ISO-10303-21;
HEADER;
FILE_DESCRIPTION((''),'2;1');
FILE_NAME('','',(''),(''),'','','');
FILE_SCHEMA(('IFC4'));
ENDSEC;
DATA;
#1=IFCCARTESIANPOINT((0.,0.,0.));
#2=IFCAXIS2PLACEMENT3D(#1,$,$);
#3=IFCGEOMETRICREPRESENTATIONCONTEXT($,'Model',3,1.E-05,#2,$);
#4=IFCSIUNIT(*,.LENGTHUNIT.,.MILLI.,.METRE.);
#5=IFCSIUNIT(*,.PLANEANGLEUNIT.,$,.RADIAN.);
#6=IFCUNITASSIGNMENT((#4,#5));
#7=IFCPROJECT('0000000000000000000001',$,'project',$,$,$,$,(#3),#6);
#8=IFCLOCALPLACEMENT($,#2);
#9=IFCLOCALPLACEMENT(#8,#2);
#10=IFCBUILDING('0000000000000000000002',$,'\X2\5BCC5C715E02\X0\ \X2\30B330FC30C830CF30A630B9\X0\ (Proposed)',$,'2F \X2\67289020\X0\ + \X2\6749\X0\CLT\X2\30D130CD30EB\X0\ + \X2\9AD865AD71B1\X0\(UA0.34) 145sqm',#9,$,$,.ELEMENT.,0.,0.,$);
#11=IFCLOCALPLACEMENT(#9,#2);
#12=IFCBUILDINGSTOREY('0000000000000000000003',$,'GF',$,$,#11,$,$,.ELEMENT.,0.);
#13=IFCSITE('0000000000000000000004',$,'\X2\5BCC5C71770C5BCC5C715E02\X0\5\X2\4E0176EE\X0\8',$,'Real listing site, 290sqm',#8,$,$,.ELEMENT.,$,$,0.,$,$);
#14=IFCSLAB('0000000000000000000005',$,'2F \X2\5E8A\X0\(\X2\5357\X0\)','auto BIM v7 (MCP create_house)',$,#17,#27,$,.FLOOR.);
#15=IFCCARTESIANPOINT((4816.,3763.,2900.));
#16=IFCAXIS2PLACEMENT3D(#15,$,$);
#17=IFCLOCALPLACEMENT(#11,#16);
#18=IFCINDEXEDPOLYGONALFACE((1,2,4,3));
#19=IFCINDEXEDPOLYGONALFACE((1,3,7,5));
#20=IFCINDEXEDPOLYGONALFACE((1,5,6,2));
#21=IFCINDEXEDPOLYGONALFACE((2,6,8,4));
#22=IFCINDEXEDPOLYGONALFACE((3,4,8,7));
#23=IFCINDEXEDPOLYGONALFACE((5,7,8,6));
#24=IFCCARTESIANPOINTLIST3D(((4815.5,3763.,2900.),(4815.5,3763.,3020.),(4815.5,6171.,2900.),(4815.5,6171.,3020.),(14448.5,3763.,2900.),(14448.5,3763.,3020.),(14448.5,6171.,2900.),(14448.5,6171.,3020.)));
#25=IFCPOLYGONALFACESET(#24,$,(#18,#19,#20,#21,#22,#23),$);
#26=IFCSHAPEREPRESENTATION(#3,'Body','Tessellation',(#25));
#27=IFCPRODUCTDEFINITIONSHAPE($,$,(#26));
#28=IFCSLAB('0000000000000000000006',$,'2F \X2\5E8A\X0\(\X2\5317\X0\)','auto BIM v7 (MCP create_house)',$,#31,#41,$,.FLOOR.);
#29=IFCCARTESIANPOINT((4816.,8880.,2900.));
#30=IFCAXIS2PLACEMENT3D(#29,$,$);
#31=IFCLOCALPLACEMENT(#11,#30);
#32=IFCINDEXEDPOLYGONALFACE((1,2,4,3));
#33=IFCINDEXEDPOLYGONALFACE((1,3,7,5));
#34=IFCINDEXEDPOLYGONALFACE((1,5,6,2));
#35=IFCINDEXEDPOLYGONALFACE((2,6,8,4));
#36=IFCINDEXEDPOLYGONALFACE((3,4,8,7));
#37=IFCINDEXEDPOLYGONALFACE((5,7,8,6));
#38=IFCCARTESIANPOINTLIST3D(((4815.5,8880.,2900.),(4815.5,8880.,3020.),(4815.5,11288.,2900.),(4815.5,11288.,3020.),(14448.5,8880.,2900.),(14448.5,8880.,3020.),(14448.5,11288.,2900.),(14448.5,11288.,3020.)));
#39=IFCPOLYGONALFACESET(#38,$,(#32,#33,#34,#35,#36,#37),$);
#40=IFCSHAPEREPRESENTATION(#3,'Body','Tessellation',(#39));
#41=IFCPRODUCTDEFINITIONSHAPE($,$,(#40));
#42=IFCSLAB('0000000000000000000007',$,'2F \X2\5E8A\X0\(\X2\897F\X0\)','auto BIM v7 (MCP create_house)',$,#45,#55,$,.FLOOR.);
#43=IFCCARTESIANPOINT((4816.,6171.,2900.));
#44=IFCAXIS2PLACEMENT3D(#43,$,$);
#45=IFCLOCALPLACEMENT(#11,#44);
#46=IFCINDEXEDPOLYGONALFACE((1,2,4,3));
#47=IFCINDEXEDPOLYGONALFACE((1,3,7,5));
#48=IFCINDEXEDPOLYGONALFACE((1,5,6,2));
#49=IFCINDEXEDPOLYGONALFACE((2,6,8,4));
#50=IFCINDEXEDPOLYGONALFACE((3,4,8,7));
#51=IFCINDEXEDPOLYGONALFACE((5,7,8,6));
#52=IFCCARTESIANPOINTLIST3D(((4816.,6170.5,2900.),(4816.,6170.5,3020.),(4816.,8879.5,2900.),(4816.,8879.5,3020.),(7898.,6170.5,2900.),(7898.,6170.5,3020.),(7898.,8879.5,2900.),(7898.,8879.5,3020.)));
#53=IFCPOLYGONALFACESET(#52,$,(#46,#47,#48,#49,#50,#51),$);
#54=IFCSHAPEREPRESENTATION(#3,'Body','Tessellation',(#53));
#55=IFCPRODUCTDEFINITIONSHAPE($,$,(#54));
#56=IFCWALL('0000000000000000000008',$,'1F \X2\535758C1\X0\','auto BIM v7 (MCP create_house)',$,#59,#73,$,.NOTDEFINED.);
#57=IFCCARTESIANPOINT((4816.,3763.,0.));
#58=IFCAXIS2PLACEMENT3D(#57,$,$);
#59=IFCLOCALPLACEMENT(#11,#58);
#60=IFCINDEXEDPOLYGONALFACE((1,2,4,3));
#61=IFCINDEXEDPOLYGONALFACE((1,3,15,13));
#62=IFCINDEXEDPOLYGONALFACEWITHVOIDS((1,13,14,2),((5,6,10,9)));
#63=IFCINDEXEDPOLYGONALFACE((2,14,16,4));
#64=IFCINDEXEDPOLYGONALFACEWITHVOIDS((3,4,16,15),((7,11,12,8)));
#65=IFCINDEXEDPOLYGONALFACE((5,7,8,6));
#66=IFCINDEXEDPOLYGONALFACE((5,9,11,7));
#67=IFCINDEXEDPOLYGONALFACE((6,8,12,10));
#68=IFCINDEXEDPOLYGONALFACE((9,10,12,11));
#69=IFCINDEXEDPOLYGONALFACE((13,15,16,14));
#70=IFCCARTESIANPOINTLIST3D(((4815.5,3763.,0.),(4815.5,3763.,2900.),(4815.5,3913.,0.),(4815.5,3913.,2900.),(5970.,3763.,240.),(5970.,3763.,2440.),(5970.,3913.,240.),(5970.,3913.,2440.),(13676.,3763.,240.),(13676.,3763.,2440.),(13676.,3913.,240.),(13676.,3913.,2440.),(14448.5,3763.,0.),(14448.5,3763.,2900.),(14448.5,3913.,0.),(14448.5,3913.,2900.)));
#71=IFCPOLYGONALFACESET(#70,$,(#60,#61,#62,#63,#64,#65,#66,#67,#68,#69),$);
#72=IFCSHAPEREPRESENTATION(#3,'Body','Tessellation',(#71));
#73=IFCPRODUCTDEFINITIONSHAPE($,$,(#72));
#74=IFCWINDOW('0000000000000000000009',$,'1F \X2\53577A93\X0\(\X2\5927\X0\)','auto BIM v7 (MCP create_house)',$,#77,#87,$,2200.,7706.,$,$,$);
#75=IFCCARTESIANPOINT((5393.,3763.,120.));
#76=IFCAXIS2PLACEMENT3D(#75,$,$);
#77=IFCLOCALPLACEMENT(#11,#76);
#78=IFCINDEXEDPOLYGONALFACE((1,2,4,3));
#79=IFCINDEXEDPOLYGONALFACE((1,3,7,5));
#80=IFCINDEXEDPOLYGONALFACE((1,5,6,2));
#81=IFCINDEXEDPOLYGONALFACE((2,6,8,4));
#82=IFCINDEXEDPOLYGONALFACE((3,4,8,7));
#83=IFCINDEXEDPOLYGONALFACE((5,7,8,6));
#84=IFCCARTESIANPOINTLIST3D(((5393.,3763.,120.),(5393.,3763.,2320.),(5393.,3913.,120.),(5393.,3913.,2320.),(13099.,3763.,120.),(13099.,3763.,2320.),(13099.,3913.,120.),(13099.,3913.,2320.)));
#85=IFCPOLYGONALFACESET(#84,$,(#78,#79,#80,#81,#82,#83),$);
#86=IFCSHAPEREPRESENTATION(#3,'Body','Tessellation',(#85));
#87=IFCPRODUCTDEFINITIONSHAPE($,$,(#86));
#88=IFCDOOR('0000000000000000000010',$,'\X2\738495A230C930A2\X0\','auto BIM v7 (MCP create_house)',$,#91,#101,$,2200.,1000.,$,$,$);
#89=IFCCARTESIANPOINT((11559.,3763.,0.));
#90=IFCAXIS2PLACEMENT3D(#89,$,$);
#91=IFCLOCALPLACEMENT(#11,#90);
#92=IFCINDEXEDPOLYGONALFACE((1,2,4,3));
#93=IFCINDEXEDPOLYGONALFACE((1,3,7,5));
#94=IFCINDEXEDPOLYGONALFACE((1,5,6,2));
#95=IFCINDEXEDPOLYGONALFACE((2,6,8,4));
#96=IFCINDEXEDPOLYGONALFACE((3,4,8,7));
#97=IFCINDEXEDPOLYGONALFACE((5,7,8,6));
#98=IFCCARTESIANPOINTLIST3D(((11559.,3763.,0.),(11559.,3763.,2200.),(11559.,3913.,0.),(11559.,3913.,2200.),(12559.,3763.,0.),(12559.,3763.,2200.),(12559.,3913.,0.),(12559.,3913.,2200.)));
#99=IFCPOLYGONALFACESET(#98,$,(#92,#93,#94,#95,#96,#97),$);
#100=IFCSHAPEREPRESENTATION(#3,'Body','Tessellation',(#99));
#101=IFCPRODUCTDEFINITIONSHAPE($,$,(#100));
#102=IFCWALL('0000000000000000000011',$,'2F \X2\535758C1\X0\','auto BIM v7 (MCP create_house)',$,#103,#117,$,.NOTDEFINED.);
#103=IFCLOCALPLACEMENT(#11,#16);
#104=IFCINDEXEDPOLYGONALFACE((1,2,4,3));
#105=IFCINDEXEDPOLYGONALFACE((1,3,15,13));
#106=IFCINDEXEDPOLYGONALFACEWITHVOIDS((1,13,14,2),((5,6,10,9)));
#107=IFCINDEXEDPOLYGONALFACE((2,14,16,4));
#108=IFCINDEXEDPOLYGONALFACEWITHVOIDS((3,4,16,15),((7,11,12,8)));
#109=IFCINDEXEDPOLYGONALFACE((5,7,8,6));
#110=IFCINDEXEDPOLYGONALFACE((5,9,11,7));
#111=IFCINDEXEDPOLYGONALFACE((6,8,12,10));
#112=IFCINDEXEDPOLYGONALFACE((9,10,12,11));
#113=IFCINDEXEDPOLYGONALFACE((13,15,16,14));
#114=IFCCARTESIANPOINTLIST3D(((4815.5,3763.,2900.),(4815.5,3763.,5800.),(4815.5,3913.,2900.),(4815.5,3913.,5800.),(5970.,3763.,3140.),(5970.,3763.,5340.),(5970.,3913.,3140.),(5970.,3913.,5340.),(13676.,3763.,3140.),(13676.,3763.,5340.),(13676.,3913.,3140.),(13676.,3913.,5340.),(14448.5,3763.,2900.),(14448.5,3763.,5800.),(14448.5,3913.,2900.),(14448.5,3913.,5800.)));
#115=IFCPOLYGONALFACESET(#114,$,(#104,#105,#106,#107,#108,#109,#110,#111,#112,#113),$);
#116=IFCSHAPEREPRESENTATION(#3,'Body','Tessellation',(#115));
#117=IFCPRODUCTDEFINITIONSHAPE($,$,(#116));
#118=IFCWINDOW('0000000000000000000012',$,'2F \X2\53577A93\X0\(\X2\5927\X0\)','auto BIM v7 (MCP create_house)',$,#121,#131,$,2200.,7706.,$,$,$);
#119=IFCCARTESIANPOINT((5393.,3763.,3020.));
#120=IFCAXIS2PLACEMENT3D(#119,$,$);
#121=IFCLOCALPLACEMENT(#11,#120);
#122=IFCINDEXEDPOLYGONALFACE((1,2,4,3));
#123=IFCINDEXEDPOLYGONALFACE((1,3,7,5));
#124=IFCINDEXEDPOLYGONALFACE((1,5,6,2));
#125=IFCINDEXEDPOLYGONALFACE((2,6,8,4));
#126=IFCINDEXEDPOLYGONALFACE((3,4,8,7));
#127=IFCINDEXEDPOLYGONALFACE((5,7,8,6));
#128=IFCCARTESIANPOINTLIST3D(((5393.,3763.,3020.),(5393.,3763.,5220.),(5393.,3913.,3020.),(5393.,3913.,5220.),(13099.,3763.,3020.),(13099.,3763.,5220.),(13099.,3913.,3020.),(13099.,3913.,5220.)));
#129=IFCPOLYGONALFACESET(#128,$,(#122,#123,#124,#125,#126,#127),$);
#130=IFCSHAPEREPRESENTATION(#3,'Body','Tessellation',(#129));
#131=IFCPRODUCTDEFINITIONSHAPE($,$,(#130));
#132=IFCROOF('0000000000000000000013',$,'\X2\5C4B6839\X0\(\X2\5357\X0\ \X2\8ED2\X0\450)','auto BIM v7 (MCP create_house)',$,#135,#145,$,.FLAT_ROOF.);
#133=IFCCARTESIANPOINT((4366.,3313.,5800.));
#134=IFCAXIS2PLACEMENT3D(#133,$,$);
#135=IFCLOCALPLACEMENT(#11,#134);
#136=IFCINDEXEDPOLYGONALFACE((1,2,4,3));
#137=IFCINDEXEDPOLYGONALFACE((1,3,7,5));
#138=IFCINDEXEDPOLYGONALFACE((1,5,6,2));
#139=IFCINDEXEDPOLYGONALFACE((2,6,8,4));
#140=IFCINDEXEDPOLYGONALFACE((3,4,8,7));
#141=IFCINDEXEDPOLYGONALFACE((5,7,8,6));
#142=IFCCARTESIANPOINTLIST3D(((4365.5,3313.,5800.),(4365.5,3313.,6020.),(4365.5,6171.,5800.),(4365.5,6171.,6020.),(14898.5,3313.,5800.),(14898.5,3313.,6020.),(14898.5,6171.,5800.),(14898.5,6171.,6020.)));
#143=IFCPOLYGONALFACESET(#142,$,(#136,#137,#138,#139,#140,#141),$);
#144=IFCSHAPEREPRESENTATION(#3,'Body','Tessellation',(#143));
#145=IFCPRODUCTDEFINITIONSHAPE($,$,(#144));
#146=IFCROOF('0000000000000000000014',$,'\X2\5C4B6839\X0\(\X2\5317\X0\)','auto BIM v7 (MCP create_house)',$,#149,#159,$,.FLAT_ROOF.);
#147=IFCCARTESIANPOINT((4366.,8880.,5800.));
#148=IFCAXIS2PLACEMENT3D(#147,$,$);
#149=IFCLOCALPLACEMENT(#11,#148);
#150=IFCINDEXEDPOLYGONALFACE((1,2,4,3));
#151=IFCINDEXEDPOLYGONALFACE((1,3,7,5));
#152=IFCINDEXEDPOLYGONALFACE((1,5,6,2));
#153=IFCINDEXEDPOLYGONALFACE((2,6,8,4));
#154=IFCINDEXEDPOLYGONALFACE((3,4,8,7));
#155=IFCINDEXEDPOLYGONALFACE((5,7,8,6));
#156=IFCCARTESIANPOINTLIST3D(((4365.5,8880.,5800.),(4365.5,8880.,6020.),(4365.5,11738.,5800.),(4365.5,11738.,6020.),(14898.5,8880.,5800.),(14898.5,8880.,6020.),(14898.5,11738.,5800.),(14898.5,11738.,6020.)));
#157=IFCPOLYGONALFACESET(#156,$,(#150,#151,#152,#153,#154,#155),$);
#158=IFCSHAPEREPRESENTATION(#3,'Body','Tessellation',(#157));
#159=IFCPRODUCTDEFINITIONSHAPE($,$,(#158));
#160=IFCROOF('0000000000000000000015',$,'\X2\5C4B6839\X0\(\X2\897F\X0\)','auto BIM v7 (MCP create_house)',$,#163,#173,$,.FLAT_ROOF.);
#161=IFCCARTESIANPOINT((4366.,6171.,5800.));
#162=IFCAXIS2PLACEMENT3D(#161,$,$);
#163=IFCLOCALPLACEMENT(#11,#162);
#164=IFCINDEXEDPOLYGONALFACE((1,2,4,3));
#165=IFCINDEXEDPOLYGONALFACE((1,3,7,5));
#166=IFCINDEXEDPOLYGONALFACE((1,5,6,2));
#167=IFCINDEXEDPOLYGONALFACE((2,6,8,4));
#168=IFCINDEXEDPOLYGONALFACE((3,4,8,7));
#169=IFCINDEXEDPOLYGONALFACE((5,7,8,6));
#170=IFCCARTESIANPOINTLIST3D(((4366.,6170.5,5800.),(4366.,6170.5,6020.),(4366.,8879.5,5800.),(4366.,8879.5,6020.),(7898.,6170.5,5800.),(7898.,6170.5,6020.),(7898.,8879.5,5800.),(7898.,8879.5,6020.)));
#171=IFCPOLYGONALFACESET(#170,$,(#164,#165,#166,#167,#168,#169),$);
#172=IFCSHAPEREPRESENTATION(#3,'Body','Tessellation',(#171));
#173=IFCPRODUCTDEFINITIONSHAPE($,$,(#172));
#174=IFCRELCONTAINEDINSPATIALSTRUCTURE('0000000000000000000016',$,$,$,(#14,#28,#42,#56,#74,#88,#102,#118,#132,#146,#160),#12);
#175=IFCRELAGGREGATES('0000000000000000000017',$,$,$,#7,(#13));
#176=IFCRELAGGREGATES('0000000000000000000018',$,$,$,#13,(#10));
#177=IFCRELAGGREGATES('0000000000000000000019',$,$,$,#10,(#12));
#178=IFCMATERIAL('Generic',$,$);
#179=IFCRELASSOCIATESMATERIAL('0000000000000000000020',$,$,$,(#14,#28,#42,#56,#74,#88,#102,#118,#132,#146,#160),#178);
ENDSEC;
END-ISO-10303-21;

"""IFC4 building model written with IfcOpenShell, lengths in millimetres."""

from ifc_helpers import new_model, si_unit, frame, frame_2d, origin, place, context, project, spatial, rectangle, extrude, material, element, fill, save


model = new_model("IFC4")

# Units and contexts
model_context = context("Model", 3, precision=1e-05, world=origin())
ifc_project = project(units=[si_unit("LENGTHUNIT", "METRE", prefix="MILLI"), si_unit("PLANEANGLEUNIT", "RADIAN")], contexts=[model_context])

# Site, building, storey
site_placement = place(None, origin())
site = spatial("IfcSite", under=ifc_project, at=site_placement, Name="富山県富山市5丁目8", ObjectType="Real listing site, 290sqm", CompositionType="ELEMENT", RefElevation=0.0)
building_placement = place(site_placement, origin())
building = spatial("IfcBuilding", under=site, at=building_placement, Name="富山市 コートハウス (Proposed)", ObjectType="2F 木造 + 杉CLTパネル + 高断熱(UA0.34) 145sqm", CompositionType="ELEMENT", ElevationOfRefHeight=0.0, ElevationOfTerrain=0.0)
storey_placement = place(building_placement, origin())
storey = spatial("IfcBuildingStorey", under=building, at=storey_placement, Name="GF", CompositionType="ELEMENT", Elevation=0.0)

# Slabs
ifc_material = material(Name="Generic")
slab_1_placement = place(storey_placement, frame((4816.0, 3763.0, 2900.0)))
element("IfcSlab", 1, at=slab_1_placement, inside=storey, material=ifc_material, Name="2F 床(南)", Description="auto BIM v7 (MCP create_house)", PredefinedType="FLOOR", context=model_context, shape_type="SweptSolid", body=[
    extrude(rectangle(XDim=9633.0, YDim=2408.0, at=frame_2d((4816.0, 1204.0))), frame((4816.0, 3763.0, 2900.0)), (0.0, 0.0, 1.0), 120.0),
])
slab_2_placement = place(storey_placement, frame((4816.0, 8880.0, 2900.0)))
element("IfcSlab", 2, at=slab_2_placement, inside=storey, material=ifc_material, Name="2F 床(北)", Description="auto BIM v7 (MCP create_house)", PredefinedType="FLOOR", context=model_context, shape_type="SweptSolid", body=[
    extrude(rectangle(XDim=9633.0, YDim=2408.0, at=frame_2d((4816.0, 1204.0))), frame((4816.0, 8880.0, 2900.0)), (0.0, 0.0, 1.0), 120.0),
])
slab_3_placement = place(storey_placement, frame((4816.0, 6171.0, 2900.0)))
element("IfcSlab", 3, at=slab_3_placement, inside=storey, material=ifc_material, Name="2F 床(西)", Description="auto BIM v7 (MCP create_house)", PredefinedType="FLOOR", context=model_context, shape_type="SweptSolid", body=[
    extrude(rectangle(XDim=3082.0, YDim=2709.0, at=frame_2d((1541.0, 1354.0))), frame((4816.0, 6171.0, 2900.0)), (0.0, 0.0, 1.0), 120.0),
])

# Wall, openings, window, door
wall_1_placement = place(storey_placement, frame((4816.0, 3763.0, 0.0)))
wall_1 = element("IfcWall", 4, at=wall_1_placement, inside=storey, material=ifc_material, Name="1F 南壁", Description="auto BIM v7 (MCP create_house)", PredefinedType="NOTDEFINED", context=model_context, shape_type="SweptSolid", body=[
    extrude(rectangle(XDim=9633.0, YDim=150.0, at=frame_2d((4816.0, 75.0))), frame((4816.0, 3763.0, 0.0)), (0.0, 0.0, 1.0), 2900.0),
])
opening_1_placement = place(storey_placement, frame((5393.0, 3763.0, 120.0)))
opening_1 = element("IfcOpeningElement", 5, at=opening_1_placement, cuts=wall_1, PredefinedType="NOTDEFINED", context=model_context, shape_type="SweptSolid", body=[
    extrude(rectangle(XDim=7706.0, YDim=150.0, at=frame_2d((3853.0, 75.0))), frame((5393.0, 3763.0, 120.0)), (0.0, 0.0, 1.0), 2200.0),
])
opening_2_placement = place(storey_placement, frame((11559.0, 3763.0, 0.0)))
opening_2 = element("IfcOpeningElement", 6, at=opening_2_placement, cuts=wall_1, PredefinedType="NOTDEFINED", context=model_context, shape_type="SweptSolid", body=[
    extrude(rectangle(XDim=1000.0, YDim=150.0, at=frame_2d((500.0, 75.0))), frame((11559.0, 3763.0, 0.0)), (0.0, 0.0, 1.0), 2200.0),
])
window_1_placement = place(storey_placement, frame((5393.0, 3763.0, 120.0)))
window_1 = element("IfcWindow", 7, at=window_1_placement, inside=storey, material=ifc_material, Name="1F 南窓(大)", Description="auto BIM v7 (MCP create_house)", OverallHeight=2200.0, OverallWidth=7706.0, context=model_context, shape_type="SweptSolid", body=[
    extrude(rectangle(XDim=7706.0, YDim=150.0, at=frame_2d((3853.0, 75.0))), frame((5393.0, 3763.0, 120.0)), (0.0, 0.0, 1.0), 2200.0),
])
fill(opening_1, window_1)
door_placement = place(storey_placement, frame((11559.0, 3763.0, 0.0)))
door = element("IfcDoor", 8, at=door_placement, inside=storey, material=ifc_material, Name="玄関ドア", Description="auto BIM v7 (MCP create_house)", OverallHeight=2200.0, OverallWidth=1000.0, context=model_context, shape_type="SweptSolid", body=[
    extrude(rectangle(XDim=1000.0, YDim=150.0, at=frame_2d((500.0, 75.0))), frame((11559.0, 3763.0, 0.0)), (0.0, 0.0, 1.0), 2200.0),
])
fill(opening_2, door)

# Wall, opening, window
wall_2_placement = place(storey_placement, frame((4816.0, 3763.0, 2900.0)))
wall_2 = element("IfcWall", 9, at=wall_2_placement, inside=storey, material=ifc_material, Name="2F 南壁", Description="auto BIM v7 (MCP create_house)", PredefinedType="NOTDEFINED", context=model_context, shape_type="SweptSolid", body=[
    extrude(rectangle(XDim=9633.0, YDim=150.0, at=frame_2d((4816.0, 75.0))), frame((4816.0, 3763.0, 2900.0)), (0.0, 0.0, 1.0), 2900.0),
])
opening_3_placement = place(storey_placement, frame((5393.0, 3763.0, 3020.0)))
opening_3 = element("IfcOpeningElement", 10, at=opening_3_placement, cuts=wall_2, PredefinedType="NOTDEFINED", context=model_context, shape_type="SweptSolid", body=[
    extrude(rectangle(XDim=7706.0, YDim=150.0, at=frame_2d((3853.0, 75.0))), frame((5393.0, 3763.0, 3020.0)), (0.0, 0.0, 1.0), 2200.0),
])
window_2_placement = place(storey_placement, frame((5393.0, 3763.0, 3020.0)))
window_2 = element("IfcWindow", 11, at=window_2_placement, inside=storey, material=ifc_material, Name="2F 南窓(大)", Description="auto BIM v7 (MCP create_house)", OverallHeight=2200.0, OverallWidth=7706.0, context=model_context, shape_type="SweptSolid", body=[
    extrude(rectangle(XDim=7706.0, YDim=150.0, at=frame_2d((3853.0, 75.0))), frame((5393.0, 3763.0, 3020.0)), (0.0, 0.0, 1.0), 2200.0),
])
fill(opening_3, window_2)

# Roofs
roof_1_placement = place(storey_placement, frame((4366.0, 3313.0, 5800.0)))
element("IfcRoof", 12, at=roof_1_placement, inside=storey, material=ifc_material, Name="屋根(南 軒450)", Description="auto BIM v7 (MCP create_house)", PredefinedType="FLAT_ROOF", context=model_context, shape_type="SweptSolid", body=[
    extrude(rectangle(XDim=10533.0, YDim=2858.0, at=frame_2d((5266.0, 1429.0))), frame((4366.0, 3313.0, 5800.0)), (0.0, 0.0, 1.0), 220.0),
])
roof_2_placement = place(storey_placement, frame((4366.0, 8880.0, 5800.0)))
element("IfcRoof", 13, at=roof_2_placement, inside=storey, material=ifc_material, Name="屋根(北)", Description="auto BIM v7 (MCP create_house)", PredefinedType="FLAT_ROOF", context=model_context, shape_type="SweptSolid", body=[
    extrude(rectangle(XDim=10533.0, YDim=2858.0, at=frame_2d((5266.0, 1429.0))), frame((4366.0, 8880.0, 5800.0)), (0.0, 0.0, 1.0), 220.0),
])
roof_3_placement = place(storey_placement, frame((4366.0, 6171.0, 5800.0)))
element("IfcRoof", 14, at=roof_3_placement, inside=storey, material=ifc_material, Name="屋根(西)", Description="auto BIM v7 (MCP create_house)", PredefinedType="FLAT_ROOF", context=model_context, shape_type="SweptSolid", body=[
    extrude(rectangle(XDim=3532.0, YDim=2709.0, at=frame_2d((1766.0, 1354.0))), frame((4366.0, 6171.0, 5800.0)), (0.0, 0.0, 1.0), 220.0),
])

save(model, "model.ifc")
